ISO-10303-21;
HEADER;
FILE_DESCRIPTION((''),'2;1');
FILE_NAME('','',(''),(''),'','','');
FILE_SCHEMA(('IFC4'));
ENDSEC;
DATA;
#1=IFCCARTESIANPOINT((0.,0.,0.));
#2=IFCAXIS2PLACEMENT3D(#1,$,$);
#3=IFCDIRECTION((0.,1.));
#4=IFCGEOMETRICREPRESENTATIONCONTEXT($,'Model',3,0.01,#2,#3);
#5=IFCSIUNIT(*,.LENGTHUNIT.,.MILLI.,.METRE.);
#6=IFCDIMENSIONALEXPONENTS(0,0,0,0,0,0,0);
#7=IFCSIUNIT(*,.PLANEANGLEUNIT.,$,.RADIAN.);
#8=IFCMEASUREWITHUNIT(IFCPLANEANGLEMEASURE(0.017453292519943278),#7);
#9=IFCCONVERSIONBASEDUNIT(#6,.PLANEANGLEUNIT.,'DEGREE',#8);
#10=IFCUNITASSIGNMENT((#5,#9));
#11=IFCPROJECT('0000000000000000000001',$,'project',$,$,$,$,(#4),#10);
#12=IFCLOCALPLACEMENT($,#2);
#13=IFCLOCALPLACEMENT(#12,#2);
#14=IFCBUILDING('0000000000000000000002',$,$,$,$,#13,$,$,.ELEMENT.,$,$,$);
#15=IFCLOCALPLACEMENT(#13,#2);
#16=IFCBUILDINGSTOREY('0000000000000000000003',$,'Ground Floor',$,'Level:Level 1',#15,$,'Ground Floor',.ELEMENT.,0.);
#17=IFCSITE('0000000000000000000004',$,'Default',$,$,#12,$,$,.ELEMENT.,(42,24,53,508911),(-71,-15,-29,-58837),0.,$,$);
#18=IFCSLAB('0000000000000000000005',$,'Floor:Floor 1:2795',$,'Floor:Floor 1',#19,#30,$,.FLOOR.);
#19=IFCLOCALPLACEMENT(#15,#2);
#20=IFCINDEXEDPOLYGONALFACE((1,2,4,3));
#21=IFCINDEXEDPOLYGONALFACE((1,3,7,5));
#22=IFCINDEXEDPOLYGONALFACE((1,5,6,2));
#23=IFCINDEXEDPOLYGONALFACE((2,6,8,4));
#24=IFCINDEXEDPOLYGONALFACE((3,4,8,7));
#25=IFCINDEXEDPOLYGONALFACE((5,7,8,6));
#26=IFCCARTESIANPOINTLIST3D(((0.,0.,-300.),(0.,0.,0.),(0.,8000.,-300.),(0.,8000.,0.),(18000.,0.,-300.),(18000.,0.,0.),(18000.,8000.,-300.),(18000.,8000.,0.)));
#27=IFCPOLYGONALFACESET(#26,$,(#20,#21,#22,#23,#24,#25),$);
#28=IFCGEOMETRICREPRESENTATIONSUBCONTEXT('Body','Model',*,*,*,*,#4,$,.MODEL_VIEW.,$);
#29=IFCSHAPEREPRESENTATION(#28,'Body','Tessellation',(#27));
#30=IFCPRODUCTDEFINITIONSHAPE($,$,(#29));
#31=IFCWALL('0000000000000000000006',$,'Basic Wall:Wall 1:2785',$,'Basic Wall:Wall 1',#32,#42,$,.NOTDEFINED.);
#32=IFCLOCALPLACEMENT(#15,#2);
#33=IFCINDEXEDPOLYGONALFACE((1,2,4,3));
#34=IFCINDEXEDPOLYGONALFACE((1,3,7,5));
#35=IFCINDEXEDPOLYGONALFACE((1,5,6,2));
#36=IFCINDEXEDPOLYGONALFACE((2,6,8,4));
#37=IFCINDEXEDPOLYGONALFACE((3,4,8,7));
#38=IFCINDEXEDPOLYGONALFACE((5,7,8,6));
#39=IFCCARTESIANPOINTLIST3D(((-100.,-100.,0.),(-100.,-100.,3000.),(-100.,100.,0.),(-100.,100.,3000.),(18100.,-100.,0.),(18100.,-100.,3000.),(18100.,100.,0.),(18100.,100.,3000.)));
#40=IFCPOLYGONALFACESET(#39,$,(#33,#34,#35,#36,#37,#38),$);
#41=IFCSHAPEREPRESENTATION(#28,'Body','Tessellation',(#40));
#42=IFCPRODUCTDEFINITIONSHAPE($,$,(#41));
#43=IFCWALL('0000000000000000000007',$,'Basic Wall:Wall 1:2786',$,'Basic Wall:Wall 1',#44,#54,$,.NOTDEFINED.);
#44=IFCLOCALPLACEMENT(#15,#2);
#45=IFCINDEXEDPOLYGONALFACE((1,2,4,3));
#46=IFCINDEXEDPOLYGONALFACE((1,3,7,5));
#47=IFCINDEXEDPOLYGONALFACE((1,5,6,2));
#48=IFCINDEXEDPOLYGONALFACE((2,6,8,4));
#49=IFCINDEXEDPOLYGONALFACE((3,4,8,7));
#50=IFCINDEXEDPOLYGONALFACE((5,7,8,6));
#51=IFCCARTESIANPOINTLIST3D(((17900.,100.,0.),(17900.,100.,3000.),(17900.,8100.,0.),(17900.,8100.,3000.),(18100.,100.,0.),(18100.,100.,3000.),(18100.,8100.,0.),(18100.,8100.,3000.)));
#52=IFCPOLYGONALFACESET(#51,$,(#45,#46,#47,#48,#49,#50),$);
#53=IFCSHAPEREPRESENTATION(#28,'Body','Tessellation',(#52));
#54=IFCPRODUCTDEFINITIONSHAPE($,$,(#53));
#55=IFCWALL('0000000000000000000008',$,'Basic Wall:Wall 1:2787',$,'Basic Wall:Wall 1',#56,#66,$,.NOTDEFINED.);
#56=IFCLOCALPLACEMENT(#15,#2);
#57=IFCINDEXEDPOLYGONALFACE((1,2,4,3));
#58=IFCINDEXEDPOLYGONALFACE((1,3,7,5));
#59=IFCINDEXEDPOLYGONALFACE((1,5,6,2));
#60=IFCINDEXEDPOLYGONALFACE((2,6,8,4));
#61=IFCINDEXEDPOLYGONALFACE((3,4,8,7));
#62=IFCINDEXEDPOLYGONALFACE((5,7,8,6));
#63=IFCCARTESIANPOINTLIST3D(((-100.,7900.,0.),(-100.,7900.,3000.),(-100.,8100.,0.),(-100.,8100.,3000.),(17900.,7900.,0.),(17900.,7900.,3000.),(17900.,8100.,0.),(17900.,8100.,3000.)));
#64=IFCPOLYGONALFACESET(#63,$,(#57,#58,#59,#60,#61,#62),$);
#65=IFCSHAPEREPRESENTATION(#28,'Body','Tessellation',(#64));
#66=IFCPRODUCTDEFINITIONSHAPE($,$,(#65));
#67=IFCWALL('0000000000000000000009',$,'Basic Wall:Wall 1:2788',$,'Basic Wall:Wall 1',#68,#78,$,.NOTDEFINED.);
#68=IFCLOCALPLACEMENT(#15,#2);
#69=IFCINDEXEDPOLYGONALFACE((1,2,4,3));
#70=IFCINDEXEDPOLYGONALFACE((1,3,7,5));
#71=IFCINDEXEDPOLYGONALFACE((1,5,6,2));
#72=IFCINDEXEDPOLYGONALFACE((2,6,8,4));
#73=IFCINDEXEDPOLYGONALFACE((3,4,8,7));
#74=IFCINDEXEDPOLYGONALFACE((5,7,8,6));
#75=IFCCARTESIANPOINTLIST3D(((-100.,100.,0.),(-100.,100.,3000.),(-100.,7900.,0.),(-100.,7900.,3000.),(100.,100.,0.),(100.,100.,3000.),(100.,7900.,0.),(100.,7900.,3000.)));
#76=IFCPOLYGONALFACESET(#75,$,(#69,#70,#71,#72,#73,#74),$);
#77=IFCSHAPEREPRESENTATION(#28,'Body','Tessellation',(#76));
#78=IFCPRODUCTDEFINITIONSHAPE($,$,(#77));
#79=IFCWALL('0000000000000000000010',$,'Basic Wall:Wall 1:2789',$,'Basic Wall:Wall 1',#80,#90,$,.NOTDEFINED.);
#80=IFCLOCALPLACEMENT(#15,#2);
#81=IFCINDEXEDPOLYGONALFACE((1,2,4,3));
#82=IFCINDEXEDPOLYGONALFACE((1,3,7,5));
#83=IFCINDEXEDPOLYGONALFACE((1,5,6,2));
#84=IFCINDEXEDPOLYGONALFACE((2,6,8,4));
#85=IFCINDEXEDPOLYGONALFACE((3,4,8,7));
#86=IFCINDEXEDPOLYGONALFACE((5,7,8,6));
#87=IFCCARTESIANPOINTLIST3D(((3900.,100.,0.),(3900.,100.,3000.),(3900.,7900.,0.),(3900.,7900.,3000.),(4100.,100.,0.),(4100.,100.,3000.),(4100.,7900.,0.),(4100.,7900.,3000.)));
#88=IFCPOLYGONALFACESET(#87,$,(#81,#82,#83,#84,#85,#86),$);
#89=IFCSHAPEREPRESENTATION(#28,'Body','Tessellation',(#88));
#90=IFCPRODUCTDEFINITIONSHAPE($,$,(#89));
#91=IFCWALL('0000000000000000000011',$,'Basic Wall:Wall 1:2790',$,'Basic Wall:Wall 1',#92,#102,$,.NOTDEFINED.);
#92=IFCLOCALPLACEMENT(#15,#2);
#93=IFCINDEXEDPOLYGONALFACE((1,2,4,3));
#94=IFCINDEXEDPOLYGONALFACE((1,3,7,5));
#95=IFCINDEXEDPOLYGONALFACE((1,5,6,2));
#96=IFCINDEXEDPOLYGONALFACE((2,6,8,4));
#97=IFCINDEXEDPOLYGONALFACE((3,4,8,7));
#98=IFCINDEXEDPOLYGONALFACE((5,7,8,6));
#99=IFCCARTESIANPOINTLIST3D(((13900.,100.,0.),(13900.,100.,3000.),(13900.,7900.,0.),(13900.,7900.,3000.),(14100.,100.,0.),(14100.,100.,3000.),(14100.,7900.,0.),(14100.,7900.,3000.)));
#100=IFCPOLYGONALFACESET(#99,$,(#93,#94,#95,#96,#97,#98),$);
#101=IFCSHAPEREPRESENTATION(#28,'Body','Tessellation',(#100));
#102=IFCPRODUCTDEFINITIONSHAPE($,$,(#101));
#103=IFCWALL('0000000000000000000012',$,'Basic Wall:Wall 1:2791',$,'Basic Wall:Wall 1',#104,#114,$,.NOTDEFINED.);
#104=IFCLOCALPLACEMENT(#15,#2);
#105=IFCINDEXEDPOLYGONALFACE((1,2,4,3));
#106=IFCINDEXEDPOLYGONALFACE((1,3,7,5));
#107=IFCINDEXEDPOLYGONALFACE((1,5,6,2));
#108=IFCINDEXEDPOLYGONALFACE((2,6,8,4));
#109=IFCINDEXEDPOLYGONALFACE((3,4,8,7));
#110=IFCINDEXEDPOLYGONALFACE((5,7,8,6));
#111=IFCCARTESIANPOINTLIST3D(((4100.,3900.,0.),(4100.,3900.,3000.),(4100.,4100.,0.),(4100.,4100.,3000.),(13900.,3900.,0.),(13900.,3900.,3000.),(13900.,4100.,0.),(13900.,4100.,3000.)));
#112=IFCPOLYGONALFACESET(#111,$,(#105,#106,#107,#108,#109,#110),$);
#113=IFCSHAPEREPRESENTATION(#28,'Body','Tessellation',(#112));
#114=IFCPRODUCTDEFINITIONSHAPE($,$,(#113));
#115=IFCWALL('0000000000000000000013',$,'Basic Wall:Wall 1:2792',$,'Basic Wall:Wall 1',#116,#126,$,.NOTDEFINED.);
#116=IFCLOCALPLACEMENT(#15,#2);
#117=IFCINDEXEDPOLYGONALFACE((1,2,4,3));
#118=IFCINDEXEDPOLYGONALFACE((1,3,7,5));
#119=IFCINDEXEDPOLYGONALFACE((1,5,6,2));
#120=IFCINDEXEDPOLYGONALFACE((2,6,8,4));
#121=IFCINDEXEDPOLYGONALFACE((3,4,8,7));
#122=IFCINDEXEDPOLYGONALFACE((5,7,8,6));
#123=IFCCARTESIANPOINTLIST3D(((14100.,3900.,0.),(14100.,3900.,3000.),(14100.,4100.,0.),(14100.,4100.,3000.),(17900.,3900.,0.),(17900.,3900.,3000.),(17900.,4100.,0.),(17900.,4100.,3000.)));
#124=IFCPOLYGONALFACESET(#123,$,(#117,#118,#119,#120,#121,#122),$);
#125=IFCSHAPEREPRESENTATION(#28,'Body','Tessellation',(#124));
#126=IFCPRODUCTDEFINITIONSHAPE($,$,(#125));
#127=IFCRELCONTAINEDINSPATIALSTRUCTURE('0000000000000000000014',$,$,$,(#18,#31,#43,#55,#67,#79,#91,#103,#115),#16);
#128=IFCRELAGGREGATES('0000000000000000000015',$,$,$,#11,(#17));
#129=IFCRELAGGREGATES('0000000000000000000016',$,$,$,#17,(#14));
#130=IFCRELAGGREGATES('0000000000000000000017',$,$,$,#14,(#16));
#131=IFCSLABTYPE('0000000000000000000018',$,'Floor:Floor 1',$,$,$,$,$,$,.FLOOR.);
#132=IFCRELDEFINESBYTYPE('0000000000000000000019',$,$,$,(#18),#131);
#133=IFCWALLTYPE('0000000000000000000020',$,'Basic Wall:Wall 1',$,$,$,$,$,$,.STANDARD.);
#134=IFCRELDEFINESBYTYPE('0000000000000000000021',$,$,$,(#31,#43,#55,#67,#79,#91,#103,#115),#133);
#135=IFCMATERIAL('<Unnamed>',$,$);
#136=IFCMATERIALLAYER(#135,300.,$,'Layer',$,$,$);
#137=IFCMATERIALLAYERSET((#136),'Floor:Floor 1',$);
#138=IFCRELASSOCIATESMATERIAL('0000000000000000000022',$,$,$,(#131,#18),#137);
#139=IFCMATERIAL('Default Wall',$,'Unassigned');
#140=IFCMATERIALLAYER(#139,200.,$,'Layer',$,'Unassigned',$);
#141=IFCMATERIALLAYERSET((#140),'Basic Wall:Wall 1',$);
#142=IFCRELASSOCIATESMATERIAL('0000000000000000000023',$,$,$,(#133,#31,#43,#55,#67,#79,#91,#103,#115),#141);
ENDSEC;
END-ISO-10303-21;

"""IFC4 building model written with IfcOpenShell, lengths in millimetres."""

from ifc_helpers import new_model, entity, si_unit, converted_unit, direction, frame, frame_2d, origin, origin_2d_with_axis, place, context, subcontext, project, spatial, rectangle, extrude, material, layer, layer_set, layer_usage, type_object, element, save


model = new_model("IFC4")

# Units and contexts
model_context = context("Model", 3, precision=0.01, world=origin(), true_north=direction((0.0, 1.0)))
body_context = subcontext(model_context, "Body", "Model", "MODEL_VIEW")
ifc_project = project(units=[si_unit("LENGTHUNIT", "METRE", prefix="MILLI"), converted_unit("PLANEANGLEUNIT", "DEGREE", entity("IfcPlaneAngleMeasure", 0.017453292519943278), si_unit("PLANEANGLEUNIT", "RADIAN"), dimensions=[0, 0, 0, 0, 0, 0, 0])], contexts=[model_context])

# Site, building, storey
site_placement = place(None, origin())
site = spatial("IfcSite", under=ifc_project, at=site_placement, Name="Default", CompositionType="ELEMENT", RefLatitude=(42, 24, 53, 508911), RefLongitude=(-71, -15, -29, -58837), RefElevation=0.0)
building_placement = place(site_placement, origin())
building = spatial("IfcBuilding", under=site, at=building_placement, CompositionType="ELEMENT")
storey_placement = place(building_placement, origin())
storey = spatial("IfcBuildingStorey", under=building, at=storey_placement, Name="Ground Floor", ObjectType="Level:Level 1", LongName="Ground Floor", CompositionType="ELEMENT", Elevation=0.0)

# Slab
ifc_material_1 = material(Name="<Unnamed>")
ifc_layer_1 = layer(ifc_material_1, 300.0, Name="Layer")
ifc_layer_set_1 = layer_set([ifc_layer_1], Name="Floor:Floor 1")
ifc_layer_usage_1 = layer_usage(ifc_layer_set_1, "AXIS3", "POSITIVE", 0.0)
slab_type = type_object("IfcSlabType", Name="Floor:Floor 1", PredefinedType="FLOOR", material=ifc_layer_set_1)
slab_placement = place(storey_placement, origin())
element("IfcSlab", 1, at=slab_placement, inside=storey, type_object=slab_type, material=ifc_layer_usage_1, Name="Floor:Floor 1:2795", ObjectType="Floor:Floor 1", PredefinedType="FLOOR", context=body_context, shape_type="SweptSolid", body=[
    extrude(rectangle(XDim=8000.0, YDim=18000.0, at=origin_2d_with_axis()), frame((9000.0, 4000.0, 0.0), z_axis=(0.0, 0.0, -1.0), x_axis=(0.0, 1.0, 0.0)), (0.0, 0.0, 1.0), 300.0),
])

# Walls
ifc_material_2 = material(Name="Default Wall", Category="Unassigned")
ifc_layer_2 = layer(ifc_material_2, 200.0, Name="Layer", Category="Unassigned")
ifc_layer_set_2 = layer_set([ifc_layer_2], Name="Basic Wall:Wall 1")
ifc_layer_usage_2 = layer_usage(ifc_layer_set_2, "AXIS2", "NEGATIVE", 100.0)
wall_type = type_object("IfcWallType", Name="Basic Wall:Wall 1", PredefinedType="STANDARD", material=ifc_layer_set_2)
wall_1_placement = place(storey_placement, frame((-100.0, 0.0, 0.0)))
element("IfcWall", 2, at=wall_1_placement, inside=storey, type_object=wall_type, material=ifc_layer_usage_2, Name="Basic Wall:Wall 1:2785", ObjectType="Basic Wall:Wall 1", PredefinedType="NOTDEFINED", context=body_context, shape_type="SweptSolid", body=[
    extrude(rectangle(XDim=18200.0, YDim=200.0, at=frame_2d((9100.0, 0.0), x_axis=(-1.0, 0.0))), origin(), (0.0, 0.0, 1.0), 3000.0),
])
ifc_layer_usage_3 = layer_usage(ifc_layer_set_2, "AXIS2", "NEGATIVE", 100.0)
wall_2_placement = place(storey_placement, frame((18000.0, 100.0, 0.0), z_axis=(0.0, 0.0, 1.0), x_axis=(0.0, 1.0, 0.0)))
element("IfcWall", 3, at=wall_2_placement, inside=storey, type_object=wall_type, material=ifc_layer_usage_3, Name="Basic Wall:Wall 1:2786", ObjectType="Basic Wall:Wall 1", PredefinedType="NOTDEFINED", context=body_context, shape_type="SweptSolid", body=[
    extrude(rectangle(XDim=8000.0, YDim=200.0, at=frame_2d((4000.0, 0.0), x_axis=(-1.0, 0.0))), origin(), (0.0, 0.0, 1.0), 3000.0),
])
ifc_layer_usage_4 = layer_usage(ifc_layer_set_2, "AXIS2", "NEGATIVE", 100.0)
wall_3_placement = place(storey_placement, frame((17900.0, 8000.0, 0.0), z_axis=(0.0, 0.0, 1.0), x_axis=(-1.0, 0.0, 0.0)))
element("IfcWall", 4, at=wall_3_placement, inside=storey, type_object=wall_type, material=ifc_layer_usage_4, Name="Basic Wall:Wall 1:2787", ObjectType="Basic Wall:Wall 1", PredefinedType="NOTDEFINED", context=body_context, shape_type="SweptSolid", body=[
    extrude(rectangle(XDim=18000.0, YDim=200.0, at=frame_2d((9000.0, 0.0), x_axis=(-1.0, 0.0))), origin(), (0.0, 0.0, 1.0), 3000.0),
])
ifc_layer_usage_5 = layer_usage(ifc_layer_set_2, "AXIS2", "NEGATIVE", 100.0)
wall_4_placement = place(storey_placement, frame((0.0, 7900.0, 0.0), z_axis=(0.0, 0.0, 1.0), x_axis=(0.0, -1.0, 0.0)))
element("IfcWall", 5, at=wall_4_placement, inside=storey, type_object=wall_type, material=ifc_layer_usage_5, Name="Basic Wall:Wall 1:2788", ObjectType="Basic Wall:Wall 1", PredefinedType="NOTDEFINED", context=body_context, shape_type="SweptSolid", body=[
    extrude(rectangle(XDim=7800.0, YDim=200.0, at=frame_2d((3900.0, 0.0), x_axis=(-1.0, 0.0))), origin(), (0.0, 0.0, 1.0), 3000.0),
])
ifc_layer_usage_6 = layer_usage(ifc_layer_set_2, "AXIS2", "NEGATIVE", 100.0)
wall_5_placement = place(storey_placement, frame((4000.0, 100.0, 0.0), z_axis=(0.0, 0.0, 1.0), x_axis=(0.0, 1.0, 0.0)))
element("IfcWall", 6, at=wall_5_placement, inside=storey, type_object=wall_type, material=ifc_layer_usage_6, Name="Basic Wall:Wall 1:2789", ObjectType="Basic Wall:Wall 1", PredefinedType="NOTDEFINED", context=body_context, shape_type="SweptSolid", body=[
    extrude(rectangle(XDim=7800.0, YDim=200.0, at=frame_2d((3900.0, 0.0), x_axis=(-1.0, 0.0))), origin(), (0.0, 0.0, 1.0), 3000.0),
])
ifc_layer_usage_7 = layer_usage(ifc_layer_set_2, "AXIS2", "NEGATIVE", 100.0)
wall_6_placement = place(storey_placement, frame((14000.0, 100.0, 0.0), z_axis=(0.0, 0.0, 1.0), x_axis=(0.0, 1.0, 0.0)))
element("IfcWall", 7, at=wall_6_placement, inside=storey, type_object=wall_type, material=ifc_layer_usage_7, Name="Basic Wall:Wall 1:2790", ObjectType="Basic Wall:Wall 1", PredefinedType="NOTDEFINED", context=body_context, shape_type="SweptSolid", body=[
    extrude(rectangle(XDim=7800.0, YDim=200.0, at=frame_2d((3900.0, 0.0), x_axis=(-1.0, 0.0))), origin(), (0.0, 0.0, 1.0), 3000.0),
])
ifc_layer_usage_8 = layer_usage(ifc_layer_set_2, "AXIS2", "NEGATIVE", 100.0)
wall_7_placement = place(storey_placement, frame((4100.0, 4000.0, 0.0)))
element("IfcWall", 8, at=wall_7_placement, inside=storey, type_object=wall_type, material=ifc_layer_usage_8, Name="Basic Wall:Wall 1:2791", ObjectType="Basic Wall:Wall 1", PredefinedType="NOTDEFINED", context=body_context, shape_type="SweptSolid", body=[
    extrude(rectangle(XDim=9800.0, YDim=200.0, at=frame_2d((4900.0, 0.0), x_axis=(-1.0, 0.0))), origin(), (0.0, 0.0, 1.0), 3000.0),
])
ifc_layer_usage_9 = layer_usage(ifc_layer_set_2, "AXIS2", "NEGATIVE", 100.0)
wall_8_placement = place(storey_placement, frame((14100.0, 4000.0, 0.0)))
element("IfcWall", 9, at=wall_8_placement, inside=storey, type_object=wall_type, material=ifc_layer_usage_9, Name="Basic Wall:Wall 1:2792", ObjectType="Basic Wall:Wall 1", PredefinedType="NOTDEFINED", context=body_context, shape_type="SweptSolid", body=[
    extrude(rectangle(XDim=3800.0, YDim=200.0, at=frame_2d((1900.0, 0.0), x_axis=(-1.0, 0.0))), origin(), (0.0, 0.0, 1.0), 3000.0),
])

save(model, "model.ifc")
